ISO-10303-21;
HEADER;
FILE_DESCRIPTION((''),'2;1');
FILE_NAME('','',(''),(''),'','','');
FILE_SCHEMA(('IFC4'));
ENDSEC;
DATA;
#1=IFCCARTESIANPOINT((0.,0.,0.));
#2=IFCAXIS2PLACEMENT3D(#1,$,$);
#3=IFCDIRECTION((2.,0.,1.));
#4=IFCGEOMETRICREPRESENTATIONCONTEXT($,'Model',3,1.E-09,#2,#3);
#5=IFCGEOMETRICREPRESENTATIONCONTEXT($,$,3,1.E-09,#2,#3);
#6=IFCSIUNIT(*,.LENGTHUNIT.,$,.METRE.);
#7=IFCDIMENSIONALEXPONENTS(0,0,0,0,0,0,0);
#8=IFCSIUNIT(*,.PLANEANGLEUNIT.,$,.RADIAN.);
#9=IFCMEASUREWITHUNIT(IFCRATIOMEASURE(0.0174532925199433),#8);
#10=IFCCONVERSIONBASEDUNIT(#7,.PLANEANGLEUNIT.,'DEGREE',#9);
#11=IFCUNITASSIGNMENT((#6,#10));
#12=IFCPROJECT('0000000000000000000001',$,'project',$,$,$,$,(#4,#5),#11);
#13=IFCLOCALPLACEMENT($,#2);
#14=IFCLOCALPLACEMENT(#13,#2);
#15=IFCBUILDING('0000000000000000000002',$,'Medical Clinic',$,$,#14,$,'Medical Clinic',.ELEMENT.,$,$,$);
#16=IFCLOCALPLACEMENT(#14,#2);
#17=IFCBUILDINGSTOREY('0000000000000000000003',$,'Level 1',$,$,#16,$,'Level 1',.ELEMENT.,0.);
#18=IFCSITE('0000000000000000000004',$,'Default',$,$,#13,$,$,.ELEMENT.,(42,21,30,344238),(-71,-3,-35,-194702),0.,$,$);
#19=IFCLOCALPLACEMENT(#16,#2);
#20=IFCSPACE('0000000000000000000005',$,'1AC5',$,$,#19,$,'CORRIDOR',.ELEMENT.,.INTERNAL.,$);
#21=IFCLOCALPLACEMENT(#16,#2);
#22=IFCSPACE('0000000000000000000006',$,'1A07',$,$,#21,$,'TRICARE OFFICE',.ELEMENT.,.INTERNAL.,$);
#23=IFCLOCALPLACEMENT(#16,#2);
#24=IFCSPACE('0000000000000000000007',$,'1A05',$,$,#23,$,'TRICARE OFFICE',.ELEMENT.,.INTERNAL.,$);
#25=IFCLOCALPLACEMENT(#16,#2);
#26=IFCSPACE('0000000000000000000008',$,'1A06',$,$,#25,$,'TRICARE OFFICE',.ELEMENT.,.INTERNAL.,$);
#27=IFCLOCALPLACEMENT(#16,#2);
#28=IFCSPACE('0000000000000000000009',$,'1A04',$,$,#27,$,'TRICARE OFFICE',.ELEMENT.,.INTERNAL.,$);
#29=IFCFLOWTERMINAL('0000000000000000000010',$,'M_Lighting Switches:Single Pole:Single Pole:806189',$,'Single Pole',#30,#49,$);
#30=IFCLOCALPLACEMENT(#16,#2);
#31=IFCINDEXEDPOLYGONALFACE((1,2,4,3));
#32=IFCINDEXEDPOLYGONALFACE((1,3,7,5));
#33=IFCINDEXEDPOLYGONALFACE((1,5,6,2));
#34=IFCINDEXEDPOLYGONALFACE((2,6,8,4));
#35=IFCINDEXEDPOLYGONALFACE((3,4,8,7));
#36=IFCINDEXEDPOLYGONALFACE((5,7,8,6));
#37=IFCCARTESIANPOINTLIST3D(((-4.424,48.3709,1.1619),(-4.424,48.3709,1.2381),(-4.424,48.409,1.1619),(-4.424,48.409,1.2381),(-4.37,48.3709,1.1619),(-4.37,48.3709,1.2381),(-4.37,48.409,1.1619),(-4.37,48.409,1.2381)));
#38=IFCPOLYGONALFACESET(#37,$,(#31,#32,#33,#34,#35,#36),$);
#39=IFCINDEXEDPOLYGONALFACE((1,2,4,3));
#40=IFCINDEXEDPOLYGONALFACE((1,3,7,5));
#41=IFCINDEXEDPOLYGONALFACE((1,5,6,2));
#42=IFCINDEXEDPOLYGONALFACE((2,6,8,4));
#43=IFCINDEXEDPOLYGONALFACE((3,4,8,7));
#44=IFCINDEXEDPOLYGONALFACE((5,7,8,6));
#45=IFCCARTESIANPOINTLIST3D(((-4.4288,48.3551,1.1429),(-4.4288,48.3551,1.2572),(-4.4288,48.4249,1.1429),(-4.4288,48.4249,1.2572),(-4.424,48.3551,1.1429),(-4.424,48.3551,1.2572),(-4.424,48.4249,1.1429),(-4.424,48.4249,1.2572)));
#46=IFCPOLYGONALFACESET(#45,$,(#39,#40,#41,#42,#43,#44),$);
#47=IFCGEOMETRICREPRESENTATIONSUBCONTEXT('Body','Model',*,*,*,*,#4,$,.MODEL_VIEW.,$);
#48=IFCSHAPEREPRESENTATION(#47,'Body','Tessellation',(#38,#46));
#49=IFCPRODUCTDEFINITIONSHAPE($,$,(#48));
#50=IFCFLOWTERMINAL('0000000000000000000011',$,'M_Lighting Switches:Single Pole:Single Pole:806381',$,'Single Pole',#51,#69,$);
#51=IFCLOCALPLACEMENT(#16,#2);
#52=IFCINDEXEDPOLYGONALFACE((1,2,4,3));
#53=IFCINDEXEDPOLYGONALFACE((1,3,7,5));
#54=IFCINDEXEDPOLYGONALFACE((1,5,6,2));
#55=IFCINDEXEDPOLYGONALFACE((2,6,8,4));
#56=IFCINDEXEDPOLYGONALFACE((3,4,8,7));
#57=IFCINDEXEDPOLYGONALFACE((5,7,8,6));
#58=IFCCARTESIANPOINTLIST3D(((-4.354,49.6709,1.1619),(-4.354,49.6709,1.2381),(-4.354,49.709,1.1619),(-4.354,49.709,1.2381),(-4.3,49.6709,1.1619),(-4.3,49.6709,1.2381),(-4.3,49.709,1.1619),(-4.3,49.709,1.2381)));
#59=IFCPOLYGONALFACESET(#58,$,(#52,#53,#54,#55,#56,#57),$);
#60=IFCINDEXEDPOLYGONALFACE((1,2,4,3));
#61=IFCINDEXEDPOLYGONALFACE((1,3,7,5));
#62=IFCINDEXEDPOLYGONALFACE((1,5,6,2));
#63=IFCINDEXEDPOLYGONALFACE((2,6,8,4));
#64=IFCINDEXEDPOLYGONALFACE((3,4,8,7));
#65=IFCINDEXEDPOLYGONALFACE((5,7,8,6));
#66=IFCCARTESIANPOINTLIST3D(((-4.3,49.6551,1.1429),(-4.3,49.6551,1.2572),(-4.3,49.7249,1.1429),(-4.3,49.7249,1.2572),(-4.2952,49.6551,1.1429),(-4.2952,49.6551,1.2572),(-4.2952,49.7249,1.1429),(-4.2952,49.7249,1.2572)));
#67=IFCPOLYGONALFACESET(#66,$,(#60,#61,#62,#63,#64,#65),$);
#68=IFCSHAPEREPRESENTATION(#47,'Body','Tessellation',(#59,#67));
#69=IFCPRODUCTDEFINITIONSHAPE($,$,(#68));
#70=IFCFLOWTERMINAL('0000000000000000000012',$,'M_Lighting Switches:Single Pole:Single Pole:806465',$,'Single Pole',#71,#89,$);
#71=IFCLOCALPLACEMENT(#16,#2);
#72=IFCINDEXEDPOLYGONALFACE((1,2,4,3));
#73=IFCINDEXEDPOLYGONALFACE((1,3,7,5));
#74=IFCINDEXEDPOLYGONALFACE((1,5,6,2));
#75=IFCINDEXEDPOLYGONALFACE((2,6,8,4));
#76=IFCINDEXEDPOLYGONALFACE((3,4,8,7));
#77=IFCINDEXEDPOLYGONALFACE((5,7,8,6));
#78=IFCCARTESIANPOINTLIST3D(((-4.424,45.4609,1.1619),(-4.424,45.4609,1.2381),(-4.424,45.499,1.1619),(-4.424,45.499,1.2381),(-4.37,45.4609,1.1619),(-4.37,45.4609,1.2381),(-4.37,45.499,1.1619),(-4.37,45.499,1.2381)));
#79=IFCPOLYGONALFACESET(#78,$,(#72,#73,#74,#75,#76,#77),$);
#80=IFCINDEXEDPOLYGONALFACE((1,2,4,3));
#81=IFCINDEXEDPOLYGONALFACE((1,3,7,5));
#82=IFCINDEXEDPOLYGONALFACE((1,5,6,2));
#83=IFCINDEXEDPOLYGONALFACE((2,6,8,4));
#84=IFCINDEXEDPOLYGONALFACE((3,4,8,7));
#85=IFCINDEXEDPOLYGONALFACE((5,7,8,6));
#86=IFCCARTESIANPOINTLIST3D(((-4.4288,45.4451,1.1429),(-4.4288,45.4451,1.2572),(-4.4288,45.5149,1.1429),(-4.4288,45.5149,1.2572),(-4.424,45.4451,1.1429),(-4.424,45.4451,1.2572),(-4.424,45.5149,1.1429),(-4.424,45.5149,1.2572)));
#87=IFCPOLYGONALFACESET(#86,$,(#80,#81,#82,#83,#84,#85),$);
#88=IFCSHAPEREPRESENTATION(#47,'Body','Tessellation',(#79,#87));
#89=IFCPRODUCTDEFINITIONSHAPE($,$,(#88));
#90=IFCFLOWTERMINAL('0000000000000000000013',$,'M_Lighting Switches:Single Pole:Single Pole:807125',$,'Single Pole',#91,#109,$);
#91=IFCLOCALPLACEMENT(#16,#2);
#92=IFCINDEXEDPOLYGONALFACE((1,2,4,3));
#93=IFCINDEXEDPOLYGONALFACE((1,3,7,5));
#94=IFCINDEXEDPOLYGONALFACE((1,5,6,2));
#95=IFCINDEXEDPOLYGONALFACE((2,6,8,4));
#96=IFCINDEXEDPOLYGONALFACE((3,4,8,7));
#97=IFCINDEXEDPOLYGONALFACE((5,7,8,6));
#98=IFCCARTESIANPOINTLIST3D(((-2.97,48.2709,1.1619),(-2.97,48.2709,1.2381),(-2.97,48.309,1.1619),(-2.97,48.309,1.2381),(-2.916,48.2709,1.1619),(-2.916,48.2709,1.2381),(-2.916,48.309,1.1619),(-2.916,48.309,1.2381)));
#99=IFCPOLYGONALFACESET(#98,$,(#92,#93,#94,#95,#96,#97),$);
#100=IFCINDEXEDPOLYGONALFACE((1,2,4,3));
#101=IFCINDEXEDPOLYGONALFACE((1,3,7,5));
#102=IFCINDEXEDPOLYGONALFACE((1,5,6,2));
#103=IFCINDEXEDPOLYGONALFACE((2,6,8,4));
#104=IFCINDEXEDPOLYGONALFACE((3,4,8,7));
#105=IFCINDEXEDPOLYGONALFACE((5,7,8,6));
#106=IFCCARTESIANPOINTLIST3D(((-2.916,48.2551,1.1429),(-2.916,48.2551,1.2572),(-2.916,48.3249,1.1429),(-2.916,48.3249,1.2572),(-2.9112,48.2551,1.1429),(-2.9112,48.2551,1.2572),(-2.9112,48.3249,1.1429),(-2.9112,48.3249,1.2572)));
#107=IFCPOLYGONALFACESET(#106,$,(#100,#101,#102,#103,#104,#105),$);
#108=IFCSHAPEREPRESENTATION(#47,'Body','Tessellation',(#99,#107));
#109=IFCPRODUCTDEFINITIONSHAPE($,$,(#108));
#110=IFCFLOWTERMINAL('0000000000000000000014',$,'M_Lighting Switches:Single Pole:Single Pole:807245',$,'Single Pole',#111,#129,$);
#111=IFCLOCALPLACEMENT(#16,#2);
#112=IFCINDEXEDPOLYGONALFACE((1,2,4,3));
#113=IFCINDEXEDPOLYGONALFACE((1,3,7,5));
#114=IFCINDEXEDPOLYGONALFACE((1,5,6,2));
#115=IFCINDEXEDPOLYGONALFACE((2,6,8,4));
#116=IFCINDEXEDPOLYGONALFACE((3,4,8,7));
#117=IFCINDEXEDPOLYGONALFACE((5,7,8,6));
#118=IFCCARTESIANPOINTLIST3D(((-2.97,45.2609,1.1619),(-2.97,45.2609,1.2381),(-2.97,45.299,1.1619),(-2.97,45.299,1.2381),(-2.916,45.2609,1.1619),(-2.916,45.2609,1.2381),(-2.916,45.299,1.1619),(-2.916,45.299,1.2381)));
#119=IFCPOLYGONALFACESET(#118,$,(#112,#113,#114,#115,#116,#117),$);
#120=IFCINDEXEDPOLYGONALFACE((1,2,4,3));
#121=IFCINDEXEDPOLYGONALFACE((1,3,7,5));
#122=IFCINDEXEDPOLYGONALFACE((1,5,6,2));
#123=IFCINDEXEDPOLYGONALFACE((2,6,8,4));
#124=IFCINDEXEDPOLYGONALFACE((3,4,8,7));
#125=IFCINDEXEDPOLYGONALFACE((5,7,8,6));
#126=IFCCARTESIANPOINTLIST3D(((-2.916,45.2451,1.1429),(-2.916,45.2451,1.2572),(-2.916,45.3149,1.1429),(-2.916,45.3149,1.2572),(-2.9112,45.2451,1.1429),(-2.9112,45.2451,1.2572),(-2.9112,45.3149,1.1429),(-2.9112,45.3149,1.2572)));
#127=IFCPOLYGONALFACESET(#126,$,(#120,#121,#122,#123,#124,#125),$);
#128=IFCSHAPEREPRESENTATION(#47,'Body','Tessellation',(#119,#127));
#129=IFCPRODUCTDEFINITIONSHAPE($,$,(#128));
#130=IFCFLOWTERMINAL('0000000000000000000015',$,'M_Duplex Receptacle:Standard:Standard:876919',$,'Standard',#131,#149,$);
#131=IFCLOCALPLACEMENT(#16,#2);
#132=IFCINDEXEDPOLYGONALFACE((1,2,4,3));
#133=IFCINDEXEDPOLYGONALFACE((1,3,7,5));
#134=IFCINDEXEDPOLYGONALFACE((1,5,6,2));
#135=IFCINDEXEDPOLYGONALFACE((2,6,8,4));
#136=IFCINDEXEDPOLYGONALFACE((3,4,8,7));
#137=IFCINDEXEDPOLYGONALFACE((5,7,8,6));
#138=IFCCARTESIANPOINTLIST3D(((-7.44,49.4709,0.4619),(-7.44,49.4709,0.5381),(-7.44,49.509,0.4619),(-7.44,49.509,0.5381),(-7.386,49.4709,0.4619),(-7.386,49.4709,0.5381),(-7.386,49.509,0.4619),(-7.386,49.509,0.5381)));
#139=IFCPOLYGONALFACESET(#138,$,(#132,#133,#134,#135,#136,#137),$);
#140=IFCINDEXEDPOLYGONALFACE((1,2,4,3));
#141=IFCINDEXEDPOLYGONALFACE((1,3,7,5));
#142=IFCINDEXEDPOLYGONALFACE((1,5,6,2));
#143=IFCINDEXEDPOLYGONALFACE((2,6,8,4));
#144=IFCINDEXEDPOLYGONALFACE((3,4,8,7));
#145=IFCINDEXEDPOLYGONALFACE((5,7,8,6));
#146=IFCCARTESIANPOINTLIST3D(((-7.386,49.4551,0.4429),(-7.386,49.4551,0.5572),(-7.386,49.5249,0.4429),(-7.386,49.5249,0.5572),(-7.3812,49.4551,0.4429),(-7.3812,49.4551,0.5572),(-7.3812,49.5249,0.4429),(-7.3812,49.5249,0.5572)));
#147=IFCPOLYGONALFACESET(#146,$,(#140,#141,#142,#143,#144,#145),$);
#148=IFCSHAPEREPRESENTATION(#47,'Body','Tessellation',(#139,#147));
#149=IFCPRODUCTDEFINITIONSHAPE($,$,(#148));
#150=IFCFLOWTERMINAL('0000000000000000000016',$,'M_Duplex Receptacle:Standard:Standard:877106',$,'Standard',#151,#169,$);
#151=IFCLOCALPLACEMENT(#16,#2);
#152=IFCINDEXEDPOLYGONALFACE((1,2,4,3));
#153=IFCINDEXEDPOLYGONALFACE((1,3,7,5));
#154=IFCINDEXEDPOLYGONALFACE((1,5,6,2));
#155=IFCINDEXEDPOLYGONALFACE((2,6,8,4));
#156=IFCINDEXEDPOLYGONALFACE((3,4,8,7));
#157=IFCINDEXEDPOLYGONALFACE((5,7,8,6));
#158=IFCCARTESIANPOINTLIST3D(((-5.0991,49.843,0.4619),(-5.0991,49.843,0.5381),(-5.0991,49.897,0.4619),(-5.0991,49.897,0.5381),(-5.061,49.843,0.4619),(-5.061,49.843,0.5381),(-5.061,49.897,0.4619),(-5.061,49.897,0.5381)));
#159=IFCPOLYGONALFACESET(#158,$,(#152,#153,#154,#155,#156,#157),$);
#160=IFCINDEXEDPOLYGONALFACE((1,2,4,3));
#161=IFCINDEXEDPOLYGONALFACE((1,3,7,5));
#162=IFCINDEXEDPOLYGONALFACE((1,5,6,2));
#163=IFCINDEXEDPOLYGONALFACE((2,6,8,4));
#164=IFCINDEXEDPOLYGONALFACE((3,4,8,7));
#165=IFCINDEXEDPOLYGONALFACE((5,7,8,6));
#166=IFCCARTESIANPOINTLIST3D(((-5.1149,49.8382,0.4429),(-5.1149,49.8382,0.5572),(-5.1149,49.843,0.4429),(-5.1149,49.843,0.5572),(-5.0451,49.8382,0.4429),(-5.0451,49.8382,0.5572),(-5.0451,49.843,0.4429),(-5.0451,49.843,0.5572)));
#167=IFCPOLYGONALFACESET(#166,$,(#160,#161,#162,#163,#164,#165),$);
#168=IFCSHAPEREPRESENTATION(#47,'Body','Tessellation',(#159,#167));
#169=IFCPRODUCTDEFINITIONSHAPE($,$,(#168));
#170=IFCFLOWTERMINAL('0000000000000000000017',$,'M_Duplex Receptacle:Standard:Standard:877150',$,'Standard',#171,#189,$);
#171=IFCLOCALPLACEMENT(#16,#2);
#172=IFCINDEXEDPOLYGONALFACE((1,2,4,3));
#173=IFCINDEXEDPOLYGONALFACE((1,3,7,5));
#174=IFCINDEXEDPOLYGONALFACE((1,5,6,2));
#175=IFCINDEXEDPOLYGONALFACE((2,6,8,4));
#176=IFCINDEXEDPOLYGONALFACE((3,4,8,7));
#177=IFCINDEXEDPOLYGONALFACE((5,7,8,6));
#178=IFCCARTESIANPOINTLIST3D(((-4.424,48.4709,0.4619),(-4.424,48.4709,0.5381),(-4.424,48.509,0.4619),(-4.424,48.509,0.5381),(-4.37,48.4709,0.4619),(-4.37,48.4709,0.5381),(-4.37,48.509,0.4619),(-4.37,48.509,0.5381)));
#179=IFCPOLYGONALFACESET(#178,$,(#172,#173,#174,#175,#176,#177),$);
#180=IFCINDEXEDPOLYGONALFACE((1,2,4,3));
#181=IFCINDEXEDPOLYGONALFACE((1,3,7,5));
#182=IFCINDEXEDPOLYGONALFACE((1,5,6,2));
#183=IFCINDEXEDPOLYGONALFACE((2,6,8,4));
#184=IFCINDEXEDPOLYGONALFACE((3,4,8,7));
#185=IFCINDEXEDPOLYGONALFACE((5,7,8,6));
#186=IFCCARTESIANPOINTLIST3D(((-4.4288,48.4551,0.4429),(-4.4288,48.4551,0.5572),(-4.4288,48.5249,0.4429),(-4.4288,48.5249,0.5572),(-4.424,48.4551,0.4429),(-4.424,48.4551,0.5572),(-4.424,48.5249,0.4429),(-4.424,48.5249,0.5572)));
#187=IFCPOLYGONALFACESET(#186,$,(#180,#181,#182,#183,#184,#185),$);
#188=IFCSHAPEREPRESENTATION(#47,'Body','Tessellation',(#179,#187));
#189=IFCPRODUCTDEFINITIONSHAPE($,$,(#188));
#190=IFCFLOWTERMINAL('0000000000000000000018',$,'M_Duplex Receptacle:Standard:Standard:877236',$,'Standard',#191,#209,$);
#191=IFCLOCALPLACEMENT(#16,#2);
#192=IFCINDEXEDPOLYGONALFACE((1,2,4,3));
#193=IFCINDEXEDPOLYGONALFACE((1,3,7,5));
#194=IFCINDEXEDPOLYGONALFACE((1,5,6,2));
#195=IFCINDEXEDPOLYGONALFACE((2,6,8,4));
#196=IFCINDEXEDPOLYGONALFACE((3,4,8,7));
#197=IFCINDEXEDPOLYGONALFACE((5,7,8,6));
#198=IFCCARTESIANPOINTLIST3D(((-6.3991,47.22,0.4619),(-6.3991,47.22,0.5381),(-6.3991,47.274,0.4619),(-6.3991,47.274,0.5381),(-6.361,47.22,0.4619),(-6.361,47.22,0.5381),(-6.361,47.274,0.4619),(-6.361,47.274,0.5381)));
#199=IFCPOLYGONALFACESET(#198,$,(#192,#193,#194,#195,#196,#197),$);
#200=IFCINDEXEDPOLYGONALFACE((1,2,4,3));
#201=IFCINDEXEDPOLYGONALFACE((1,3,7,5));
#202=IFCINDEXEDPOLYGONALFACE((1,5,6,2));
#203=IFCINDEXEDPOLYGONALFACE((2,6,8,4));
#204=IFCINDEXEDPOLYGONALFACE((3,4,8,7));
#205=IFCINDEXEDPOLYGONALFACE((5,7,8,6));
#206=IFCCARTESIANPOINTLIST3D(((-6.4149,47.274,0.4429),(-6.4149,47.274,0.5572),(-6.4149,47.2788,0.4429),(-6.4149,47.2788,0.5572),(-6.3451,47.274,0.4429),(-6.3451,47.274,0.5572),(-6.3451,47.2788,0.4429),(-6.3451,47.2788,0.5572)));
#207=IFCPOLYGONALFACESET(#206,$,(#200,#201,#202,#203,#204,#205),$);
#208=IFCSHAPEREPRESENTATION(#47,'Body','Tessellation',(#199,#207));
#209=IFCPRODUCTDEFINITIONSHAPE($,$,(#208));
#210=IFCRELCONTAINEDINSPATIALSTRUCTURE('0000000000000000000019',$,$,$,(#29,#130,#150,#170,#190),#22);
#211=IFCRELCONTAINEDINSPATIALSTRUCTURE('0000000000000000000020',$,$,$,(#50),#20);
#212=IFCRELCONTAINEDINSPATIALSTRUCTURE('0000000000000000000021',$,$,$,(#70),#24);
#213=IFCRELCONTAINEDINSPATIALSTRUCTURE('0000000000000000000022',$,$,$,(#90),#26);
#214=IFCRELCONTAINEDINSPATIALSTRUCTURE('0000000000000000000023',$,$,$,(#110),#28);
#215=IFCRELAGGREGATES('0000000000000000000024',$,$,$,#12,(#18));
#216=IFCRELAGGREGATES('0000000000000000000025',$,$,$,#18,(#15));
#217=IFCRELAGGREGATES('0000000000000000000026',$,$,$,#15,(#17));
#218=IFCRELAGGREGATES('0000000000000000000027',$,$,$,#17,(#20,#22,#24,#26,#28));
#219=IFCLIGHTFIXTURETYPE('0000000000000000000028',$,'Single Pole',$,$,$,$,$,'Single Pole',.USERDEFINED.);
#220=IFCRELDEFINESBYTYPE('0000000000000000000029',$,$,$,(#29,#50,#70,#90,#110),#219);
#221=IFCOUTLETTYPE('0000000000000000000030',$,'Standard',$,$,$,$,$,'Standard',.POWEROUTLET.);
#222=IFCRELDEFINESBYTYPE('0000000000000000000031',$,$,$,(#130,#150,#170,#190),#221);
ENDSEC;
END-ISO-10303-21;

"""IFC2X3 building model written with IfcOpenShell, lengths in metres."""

from ifc_helpers import new_model, entity, si_unit, converted_unit, direction, frame, frame_2d, origin, origin_2d_with_axis, place, context, subcontext, project, spatial, rectangle, extrude, source, transform, mapped, type_object, type_shapes, element, save


model = new_model("IFC2X3")

# Units and contexts
model_context = context("Model", 3, precision=1e-09, world=origin(), true_north=direction((2.0, 0.0, 1.0)))
context_of_model = context(None, 3, precision=1e-09, world=origin(), true_north=direction((2.0, 0.0, 1.0)))
body_context = subcontext(model_context, "Body", "Model", "MODEL_VIEW")
ifc_project = project(units=[si_unit("LENGTHUNIT", "METRE"), converted_unit("PLANEANGLEUNIT", "DEGREE", entity("IfcRatioMeasure", 0.0174532925199433), si_unit("PLANEANGLEUNIT", "RADIAN"), dimensions=[0, 0, 0, 0, 0, 0, 0])], contexts=[model_context, context_of_model])

# Site, building, storey, space
site_placement = place(None, origin())
site = spatial("IfcSite", under=ifc_project, at=site_placement, Name="Default", CompositionType="ELEMENT", RefLatitude=(42, 21, 30, 344238), RefLongitude=(-71, -3, -35, -194702), RefElevation=0.0)
building_placement = place(site_placement, origin())
building = spatial("IfcBuilding", under=site, at=building_placement, Name="Medical Clinic", LongName="Medical Clinic", CompositionType="ELEMENT")
storey_placement = place(building_placement, origin())
storey = spatial("IfcBuildingStorey", under=building, at=storey_placement, Name="Level 1", LongName="Level 1", CompositionType="ELEMENT", Elevation=0.0)
space_1_placement = place(storey_placement, origin())
space_1 = spatial("IfcSpace", under=storey, at=space_1_placement, Name="1AC5", LongName="CORRIDOR", CompositionType="ELEMENT", InteriorOrExteriorSpace="INTERNAL")

# Shared definitions
space_2_placement = place(storey_placement, origin())
space_2 = spatial("IfcSpace", under=storey, at=space_2_placement, Name="1A07", LongName="TRICARE OFFICE", CompositionType="ELEMENT", InteriorOrExteriorSpace="INTERNAL")

# Flow terminals
light_fixture_type_1 = type_object("IfcLightFixtureType", Name="Single Pole", ElementType="Single Pole", PredefinedType="USERDEFINED")
shared_shape_1 = source(origin(), body_context, "Body", "SweptSolid", [
    extrude(rectangle(XDim=0.0381, YDim=0.0762, at=origin_2d_with_axis()), frame((0.0, 0.0, -0.054), z_axis=(0.0, 0.0, 1.0), x_axis=(-1.0, 0.0, 0.0)), (0.0, 0.0, 1.0), 0.054),
    extrude(rectangle(XDim=0.0698, YDim=0.1143, at=frame_2d((0.0, 0.0), x_axis=(1.0, 0.0))), frame((0.0, 0.0, 0.0), z_axis=(0.0, 0.0, 1.0), x_axis=(-1.0, 0.0, 0.0)), (0.0, 0.0, 1.0), 0.0048),
])
type_shapes(light_fixture_type_1, [shared_shape_1])
flow_terminal_1_placement = place(space_2_placement, frame((-4.424, 48.39, 1.2), z_axis=(-1.0, 0.0, 0.0), x_axis=(0.0, -1.0, 0.0)))
element("IfcFlowTerminal", 1, at=flow_terminal_1_placement, inside=space_2, type_object=light_fixture_type_1, Name="M_Lighting Switches:Single Pole:Single Pole:806189", ObjectType="Single Pole", context=body_context, shape_type="MappedRepresentation", body=[
    mapped(shared_shape_1, transform((0.0, 0.0, 0.0), scale=1.0)),
])
flow_terminal_2_placement = place(space_1_placement, frame((-4.3, 49.69, 1.2), z_axis=(1.0, 0.0, 0.0), x_axis=(0.0, 1.0, 0.0)))
element("IfcFlowTerminal", 2, at=flow_terminal_2_placement, inside=space_1, type_object=light_fixture_type_1, Name="M_Lighting Switches:Single Pole:Single Pole:806381", ObjectType="Single Pole", context=body_context, shape_type="MappedRepresentation", body=[
    mapped(shared_shape_1, transform((0.0, 0.0, 0.0), scale=1.0)),
])

# Shared definitions
space_3_placement = place(storey_placement, origin())
space_3 = spatial("IfcSpace", under=storey, at=space_3_placement, Name="1A05", LongName="TRICARE OFFICE", CompositionType="ELEMENT", InteriorOrExteriorSpace="INTERNAL")

# Flow terminal
flow_terminal_3_placement = place(space_3_placement, frame((-4.424, 45.48, 1.2), z_axis=(-1.0, 0.0, 0.0), x_axis=(0.0, -1.0, 0.0)))
element("IfcFlowTerminal", 3, at=flow_terminal_3_placement, inside=space_3, type_object=light_fixture_type_1, Name="M_Lighting Switches:Single Pole:Single Pole:806465", ObjectType="Single Pole", context=body_context, shape_type="MappedRepresentation", body=[
    mapped(shared_shape_1, transform((0.0, 0.0, 0.0), scale=1.0)),
])

# Shared definitions
space_4_placement = place(storey_placement, origin())
space_4 = spatial("IfcSpace", under=storey, at=space_4_placement, Name="1A06", LongName="TRICARE OFFICE", CompositionType="ELEMENT", InteriorOrExteriorSpace="INTERNAL")

# Flow terminal
flow_terminal_4_placement = place(space_4_placement, frame((-2.916, 48.29, 1.2), z_axis=(1.0, 0.0, 0.0), x_axis=(0.0, 1.0, 0.0)))
element("IfcFlowTerminal", 4, at=flow_terminal_4_placement, inside=space_4, type_object=light_fixture_type_1, Name="M_Lighting Switches:Single Pole:Single Pole:807125", ObjectType="Single Pole", context=body_context, shape_type="MappedRepresentation", body=[
    mapped(shared_shape_1, transform((0.0, 0.0, 0.0), scale=1.0)),
])

# Shared definitions
space_5_placement = place(storey_placement, origin())
space_5 = spatial("IfcSpace", under=storey, at=space_5_placement, Name="1A04", LongName="TRICARE OFFICE", CompositionType="ELEMENT", InteriorOrExteriorSpace="INTERNAL")

# Flow terminals
flow_terminal_5_placement = place(space_5_placement, frame((-2.916, 45.28, 1.2), z_axis=(1.0, 0.0, 0.0), x_axis=(0.0, 1.0, 0.0)))
element("IfcFlowTerminal", 5, at=flow_terminal_5_placement, inside=space_5, type_object=light_fixture_type_1, Name="M_Lighting Switches:Single Pole:Single Pole:807245", ObjectType="Single Pole", context=body_context, shape_type="MappedRepresentation", body=[
    mapped(shared_shape_1, transform((0.0, 0.0, 0.0), scale=1.0)),
])
outlet_type = type_object("IfcOutletType", Name="Standard", ElementType="Standard", PredefinedType="POWEROUTLET")
shared_shape_2 = source(origin(), body_context, "Body", "SweptSolid", [
    extrude(rectangle(XDim=0.0381, YDim=0.0762, at=origin_2d_with_axis()), frame((0.0, 0.0, -0.054), z_axis=(0.0, 0.0, 1.0), x_axis=(-1.0, 0.0, 0.0)), (0.0, 0.0, 1.0), 0.054),
    extrude(rectangle(XDim=0.0698, YDim=0.1143, at=frame_2d((0.0, 0.0), x_axis=(1.0, 0.0))), frame((0.0, 0.0, 0.0), z_axis=(0.0, 0.0, 1.0), x_axis=(-1.0, 0.0, 0.0)), (0.0, 0.0, 1.0), 0.0048),
])
type_shapes(outlet_type, [shared_shape_2])
for number, where, z_axis, x_axis, name in (
    (6, (-7.386, 49.49, 0.5), (1.0, 0.0, 0.0), (0.0, 1.0, 0.0), "M_Duplex Receptacle:Standard:Standard:876919"),
    (7, (-5.08, 49.843, 0.5), (0.0, -1.0, 0.0), (1.0, 0.0, 0.0), "M_Duplex Receptacle:Standard:Standard:877106"),
    (8, (-4.424, 48.49, 0.5), (-1.0, 0.0, 0.0), (0.0, -1.0, 0.0), "M_Duplex Receptacle:Standard:Standard:877150"),
    (9, (-6.38, 47.274, 0.5), (0.0, 1.0, 0.0), (-1.0, 0.0, 0.0), "M_Duplex Receptacle:Standard:Standard:877236"),
):
    element("IfcFlowTerminal", number, at=place(space_2_placement, frame(where, z_axis=z_axis, x_axis=x_axis)), inside=space_2, type_object=outlet_type, Name=name, ObjectType="Standard", context=body_context, shape_type="MappedRepresentation", body=[
        mapped(shared_shape_2, transform((0.0, 0.0, 0.0), scale=1.0)),
    ])

save(model, "model.ifc")
